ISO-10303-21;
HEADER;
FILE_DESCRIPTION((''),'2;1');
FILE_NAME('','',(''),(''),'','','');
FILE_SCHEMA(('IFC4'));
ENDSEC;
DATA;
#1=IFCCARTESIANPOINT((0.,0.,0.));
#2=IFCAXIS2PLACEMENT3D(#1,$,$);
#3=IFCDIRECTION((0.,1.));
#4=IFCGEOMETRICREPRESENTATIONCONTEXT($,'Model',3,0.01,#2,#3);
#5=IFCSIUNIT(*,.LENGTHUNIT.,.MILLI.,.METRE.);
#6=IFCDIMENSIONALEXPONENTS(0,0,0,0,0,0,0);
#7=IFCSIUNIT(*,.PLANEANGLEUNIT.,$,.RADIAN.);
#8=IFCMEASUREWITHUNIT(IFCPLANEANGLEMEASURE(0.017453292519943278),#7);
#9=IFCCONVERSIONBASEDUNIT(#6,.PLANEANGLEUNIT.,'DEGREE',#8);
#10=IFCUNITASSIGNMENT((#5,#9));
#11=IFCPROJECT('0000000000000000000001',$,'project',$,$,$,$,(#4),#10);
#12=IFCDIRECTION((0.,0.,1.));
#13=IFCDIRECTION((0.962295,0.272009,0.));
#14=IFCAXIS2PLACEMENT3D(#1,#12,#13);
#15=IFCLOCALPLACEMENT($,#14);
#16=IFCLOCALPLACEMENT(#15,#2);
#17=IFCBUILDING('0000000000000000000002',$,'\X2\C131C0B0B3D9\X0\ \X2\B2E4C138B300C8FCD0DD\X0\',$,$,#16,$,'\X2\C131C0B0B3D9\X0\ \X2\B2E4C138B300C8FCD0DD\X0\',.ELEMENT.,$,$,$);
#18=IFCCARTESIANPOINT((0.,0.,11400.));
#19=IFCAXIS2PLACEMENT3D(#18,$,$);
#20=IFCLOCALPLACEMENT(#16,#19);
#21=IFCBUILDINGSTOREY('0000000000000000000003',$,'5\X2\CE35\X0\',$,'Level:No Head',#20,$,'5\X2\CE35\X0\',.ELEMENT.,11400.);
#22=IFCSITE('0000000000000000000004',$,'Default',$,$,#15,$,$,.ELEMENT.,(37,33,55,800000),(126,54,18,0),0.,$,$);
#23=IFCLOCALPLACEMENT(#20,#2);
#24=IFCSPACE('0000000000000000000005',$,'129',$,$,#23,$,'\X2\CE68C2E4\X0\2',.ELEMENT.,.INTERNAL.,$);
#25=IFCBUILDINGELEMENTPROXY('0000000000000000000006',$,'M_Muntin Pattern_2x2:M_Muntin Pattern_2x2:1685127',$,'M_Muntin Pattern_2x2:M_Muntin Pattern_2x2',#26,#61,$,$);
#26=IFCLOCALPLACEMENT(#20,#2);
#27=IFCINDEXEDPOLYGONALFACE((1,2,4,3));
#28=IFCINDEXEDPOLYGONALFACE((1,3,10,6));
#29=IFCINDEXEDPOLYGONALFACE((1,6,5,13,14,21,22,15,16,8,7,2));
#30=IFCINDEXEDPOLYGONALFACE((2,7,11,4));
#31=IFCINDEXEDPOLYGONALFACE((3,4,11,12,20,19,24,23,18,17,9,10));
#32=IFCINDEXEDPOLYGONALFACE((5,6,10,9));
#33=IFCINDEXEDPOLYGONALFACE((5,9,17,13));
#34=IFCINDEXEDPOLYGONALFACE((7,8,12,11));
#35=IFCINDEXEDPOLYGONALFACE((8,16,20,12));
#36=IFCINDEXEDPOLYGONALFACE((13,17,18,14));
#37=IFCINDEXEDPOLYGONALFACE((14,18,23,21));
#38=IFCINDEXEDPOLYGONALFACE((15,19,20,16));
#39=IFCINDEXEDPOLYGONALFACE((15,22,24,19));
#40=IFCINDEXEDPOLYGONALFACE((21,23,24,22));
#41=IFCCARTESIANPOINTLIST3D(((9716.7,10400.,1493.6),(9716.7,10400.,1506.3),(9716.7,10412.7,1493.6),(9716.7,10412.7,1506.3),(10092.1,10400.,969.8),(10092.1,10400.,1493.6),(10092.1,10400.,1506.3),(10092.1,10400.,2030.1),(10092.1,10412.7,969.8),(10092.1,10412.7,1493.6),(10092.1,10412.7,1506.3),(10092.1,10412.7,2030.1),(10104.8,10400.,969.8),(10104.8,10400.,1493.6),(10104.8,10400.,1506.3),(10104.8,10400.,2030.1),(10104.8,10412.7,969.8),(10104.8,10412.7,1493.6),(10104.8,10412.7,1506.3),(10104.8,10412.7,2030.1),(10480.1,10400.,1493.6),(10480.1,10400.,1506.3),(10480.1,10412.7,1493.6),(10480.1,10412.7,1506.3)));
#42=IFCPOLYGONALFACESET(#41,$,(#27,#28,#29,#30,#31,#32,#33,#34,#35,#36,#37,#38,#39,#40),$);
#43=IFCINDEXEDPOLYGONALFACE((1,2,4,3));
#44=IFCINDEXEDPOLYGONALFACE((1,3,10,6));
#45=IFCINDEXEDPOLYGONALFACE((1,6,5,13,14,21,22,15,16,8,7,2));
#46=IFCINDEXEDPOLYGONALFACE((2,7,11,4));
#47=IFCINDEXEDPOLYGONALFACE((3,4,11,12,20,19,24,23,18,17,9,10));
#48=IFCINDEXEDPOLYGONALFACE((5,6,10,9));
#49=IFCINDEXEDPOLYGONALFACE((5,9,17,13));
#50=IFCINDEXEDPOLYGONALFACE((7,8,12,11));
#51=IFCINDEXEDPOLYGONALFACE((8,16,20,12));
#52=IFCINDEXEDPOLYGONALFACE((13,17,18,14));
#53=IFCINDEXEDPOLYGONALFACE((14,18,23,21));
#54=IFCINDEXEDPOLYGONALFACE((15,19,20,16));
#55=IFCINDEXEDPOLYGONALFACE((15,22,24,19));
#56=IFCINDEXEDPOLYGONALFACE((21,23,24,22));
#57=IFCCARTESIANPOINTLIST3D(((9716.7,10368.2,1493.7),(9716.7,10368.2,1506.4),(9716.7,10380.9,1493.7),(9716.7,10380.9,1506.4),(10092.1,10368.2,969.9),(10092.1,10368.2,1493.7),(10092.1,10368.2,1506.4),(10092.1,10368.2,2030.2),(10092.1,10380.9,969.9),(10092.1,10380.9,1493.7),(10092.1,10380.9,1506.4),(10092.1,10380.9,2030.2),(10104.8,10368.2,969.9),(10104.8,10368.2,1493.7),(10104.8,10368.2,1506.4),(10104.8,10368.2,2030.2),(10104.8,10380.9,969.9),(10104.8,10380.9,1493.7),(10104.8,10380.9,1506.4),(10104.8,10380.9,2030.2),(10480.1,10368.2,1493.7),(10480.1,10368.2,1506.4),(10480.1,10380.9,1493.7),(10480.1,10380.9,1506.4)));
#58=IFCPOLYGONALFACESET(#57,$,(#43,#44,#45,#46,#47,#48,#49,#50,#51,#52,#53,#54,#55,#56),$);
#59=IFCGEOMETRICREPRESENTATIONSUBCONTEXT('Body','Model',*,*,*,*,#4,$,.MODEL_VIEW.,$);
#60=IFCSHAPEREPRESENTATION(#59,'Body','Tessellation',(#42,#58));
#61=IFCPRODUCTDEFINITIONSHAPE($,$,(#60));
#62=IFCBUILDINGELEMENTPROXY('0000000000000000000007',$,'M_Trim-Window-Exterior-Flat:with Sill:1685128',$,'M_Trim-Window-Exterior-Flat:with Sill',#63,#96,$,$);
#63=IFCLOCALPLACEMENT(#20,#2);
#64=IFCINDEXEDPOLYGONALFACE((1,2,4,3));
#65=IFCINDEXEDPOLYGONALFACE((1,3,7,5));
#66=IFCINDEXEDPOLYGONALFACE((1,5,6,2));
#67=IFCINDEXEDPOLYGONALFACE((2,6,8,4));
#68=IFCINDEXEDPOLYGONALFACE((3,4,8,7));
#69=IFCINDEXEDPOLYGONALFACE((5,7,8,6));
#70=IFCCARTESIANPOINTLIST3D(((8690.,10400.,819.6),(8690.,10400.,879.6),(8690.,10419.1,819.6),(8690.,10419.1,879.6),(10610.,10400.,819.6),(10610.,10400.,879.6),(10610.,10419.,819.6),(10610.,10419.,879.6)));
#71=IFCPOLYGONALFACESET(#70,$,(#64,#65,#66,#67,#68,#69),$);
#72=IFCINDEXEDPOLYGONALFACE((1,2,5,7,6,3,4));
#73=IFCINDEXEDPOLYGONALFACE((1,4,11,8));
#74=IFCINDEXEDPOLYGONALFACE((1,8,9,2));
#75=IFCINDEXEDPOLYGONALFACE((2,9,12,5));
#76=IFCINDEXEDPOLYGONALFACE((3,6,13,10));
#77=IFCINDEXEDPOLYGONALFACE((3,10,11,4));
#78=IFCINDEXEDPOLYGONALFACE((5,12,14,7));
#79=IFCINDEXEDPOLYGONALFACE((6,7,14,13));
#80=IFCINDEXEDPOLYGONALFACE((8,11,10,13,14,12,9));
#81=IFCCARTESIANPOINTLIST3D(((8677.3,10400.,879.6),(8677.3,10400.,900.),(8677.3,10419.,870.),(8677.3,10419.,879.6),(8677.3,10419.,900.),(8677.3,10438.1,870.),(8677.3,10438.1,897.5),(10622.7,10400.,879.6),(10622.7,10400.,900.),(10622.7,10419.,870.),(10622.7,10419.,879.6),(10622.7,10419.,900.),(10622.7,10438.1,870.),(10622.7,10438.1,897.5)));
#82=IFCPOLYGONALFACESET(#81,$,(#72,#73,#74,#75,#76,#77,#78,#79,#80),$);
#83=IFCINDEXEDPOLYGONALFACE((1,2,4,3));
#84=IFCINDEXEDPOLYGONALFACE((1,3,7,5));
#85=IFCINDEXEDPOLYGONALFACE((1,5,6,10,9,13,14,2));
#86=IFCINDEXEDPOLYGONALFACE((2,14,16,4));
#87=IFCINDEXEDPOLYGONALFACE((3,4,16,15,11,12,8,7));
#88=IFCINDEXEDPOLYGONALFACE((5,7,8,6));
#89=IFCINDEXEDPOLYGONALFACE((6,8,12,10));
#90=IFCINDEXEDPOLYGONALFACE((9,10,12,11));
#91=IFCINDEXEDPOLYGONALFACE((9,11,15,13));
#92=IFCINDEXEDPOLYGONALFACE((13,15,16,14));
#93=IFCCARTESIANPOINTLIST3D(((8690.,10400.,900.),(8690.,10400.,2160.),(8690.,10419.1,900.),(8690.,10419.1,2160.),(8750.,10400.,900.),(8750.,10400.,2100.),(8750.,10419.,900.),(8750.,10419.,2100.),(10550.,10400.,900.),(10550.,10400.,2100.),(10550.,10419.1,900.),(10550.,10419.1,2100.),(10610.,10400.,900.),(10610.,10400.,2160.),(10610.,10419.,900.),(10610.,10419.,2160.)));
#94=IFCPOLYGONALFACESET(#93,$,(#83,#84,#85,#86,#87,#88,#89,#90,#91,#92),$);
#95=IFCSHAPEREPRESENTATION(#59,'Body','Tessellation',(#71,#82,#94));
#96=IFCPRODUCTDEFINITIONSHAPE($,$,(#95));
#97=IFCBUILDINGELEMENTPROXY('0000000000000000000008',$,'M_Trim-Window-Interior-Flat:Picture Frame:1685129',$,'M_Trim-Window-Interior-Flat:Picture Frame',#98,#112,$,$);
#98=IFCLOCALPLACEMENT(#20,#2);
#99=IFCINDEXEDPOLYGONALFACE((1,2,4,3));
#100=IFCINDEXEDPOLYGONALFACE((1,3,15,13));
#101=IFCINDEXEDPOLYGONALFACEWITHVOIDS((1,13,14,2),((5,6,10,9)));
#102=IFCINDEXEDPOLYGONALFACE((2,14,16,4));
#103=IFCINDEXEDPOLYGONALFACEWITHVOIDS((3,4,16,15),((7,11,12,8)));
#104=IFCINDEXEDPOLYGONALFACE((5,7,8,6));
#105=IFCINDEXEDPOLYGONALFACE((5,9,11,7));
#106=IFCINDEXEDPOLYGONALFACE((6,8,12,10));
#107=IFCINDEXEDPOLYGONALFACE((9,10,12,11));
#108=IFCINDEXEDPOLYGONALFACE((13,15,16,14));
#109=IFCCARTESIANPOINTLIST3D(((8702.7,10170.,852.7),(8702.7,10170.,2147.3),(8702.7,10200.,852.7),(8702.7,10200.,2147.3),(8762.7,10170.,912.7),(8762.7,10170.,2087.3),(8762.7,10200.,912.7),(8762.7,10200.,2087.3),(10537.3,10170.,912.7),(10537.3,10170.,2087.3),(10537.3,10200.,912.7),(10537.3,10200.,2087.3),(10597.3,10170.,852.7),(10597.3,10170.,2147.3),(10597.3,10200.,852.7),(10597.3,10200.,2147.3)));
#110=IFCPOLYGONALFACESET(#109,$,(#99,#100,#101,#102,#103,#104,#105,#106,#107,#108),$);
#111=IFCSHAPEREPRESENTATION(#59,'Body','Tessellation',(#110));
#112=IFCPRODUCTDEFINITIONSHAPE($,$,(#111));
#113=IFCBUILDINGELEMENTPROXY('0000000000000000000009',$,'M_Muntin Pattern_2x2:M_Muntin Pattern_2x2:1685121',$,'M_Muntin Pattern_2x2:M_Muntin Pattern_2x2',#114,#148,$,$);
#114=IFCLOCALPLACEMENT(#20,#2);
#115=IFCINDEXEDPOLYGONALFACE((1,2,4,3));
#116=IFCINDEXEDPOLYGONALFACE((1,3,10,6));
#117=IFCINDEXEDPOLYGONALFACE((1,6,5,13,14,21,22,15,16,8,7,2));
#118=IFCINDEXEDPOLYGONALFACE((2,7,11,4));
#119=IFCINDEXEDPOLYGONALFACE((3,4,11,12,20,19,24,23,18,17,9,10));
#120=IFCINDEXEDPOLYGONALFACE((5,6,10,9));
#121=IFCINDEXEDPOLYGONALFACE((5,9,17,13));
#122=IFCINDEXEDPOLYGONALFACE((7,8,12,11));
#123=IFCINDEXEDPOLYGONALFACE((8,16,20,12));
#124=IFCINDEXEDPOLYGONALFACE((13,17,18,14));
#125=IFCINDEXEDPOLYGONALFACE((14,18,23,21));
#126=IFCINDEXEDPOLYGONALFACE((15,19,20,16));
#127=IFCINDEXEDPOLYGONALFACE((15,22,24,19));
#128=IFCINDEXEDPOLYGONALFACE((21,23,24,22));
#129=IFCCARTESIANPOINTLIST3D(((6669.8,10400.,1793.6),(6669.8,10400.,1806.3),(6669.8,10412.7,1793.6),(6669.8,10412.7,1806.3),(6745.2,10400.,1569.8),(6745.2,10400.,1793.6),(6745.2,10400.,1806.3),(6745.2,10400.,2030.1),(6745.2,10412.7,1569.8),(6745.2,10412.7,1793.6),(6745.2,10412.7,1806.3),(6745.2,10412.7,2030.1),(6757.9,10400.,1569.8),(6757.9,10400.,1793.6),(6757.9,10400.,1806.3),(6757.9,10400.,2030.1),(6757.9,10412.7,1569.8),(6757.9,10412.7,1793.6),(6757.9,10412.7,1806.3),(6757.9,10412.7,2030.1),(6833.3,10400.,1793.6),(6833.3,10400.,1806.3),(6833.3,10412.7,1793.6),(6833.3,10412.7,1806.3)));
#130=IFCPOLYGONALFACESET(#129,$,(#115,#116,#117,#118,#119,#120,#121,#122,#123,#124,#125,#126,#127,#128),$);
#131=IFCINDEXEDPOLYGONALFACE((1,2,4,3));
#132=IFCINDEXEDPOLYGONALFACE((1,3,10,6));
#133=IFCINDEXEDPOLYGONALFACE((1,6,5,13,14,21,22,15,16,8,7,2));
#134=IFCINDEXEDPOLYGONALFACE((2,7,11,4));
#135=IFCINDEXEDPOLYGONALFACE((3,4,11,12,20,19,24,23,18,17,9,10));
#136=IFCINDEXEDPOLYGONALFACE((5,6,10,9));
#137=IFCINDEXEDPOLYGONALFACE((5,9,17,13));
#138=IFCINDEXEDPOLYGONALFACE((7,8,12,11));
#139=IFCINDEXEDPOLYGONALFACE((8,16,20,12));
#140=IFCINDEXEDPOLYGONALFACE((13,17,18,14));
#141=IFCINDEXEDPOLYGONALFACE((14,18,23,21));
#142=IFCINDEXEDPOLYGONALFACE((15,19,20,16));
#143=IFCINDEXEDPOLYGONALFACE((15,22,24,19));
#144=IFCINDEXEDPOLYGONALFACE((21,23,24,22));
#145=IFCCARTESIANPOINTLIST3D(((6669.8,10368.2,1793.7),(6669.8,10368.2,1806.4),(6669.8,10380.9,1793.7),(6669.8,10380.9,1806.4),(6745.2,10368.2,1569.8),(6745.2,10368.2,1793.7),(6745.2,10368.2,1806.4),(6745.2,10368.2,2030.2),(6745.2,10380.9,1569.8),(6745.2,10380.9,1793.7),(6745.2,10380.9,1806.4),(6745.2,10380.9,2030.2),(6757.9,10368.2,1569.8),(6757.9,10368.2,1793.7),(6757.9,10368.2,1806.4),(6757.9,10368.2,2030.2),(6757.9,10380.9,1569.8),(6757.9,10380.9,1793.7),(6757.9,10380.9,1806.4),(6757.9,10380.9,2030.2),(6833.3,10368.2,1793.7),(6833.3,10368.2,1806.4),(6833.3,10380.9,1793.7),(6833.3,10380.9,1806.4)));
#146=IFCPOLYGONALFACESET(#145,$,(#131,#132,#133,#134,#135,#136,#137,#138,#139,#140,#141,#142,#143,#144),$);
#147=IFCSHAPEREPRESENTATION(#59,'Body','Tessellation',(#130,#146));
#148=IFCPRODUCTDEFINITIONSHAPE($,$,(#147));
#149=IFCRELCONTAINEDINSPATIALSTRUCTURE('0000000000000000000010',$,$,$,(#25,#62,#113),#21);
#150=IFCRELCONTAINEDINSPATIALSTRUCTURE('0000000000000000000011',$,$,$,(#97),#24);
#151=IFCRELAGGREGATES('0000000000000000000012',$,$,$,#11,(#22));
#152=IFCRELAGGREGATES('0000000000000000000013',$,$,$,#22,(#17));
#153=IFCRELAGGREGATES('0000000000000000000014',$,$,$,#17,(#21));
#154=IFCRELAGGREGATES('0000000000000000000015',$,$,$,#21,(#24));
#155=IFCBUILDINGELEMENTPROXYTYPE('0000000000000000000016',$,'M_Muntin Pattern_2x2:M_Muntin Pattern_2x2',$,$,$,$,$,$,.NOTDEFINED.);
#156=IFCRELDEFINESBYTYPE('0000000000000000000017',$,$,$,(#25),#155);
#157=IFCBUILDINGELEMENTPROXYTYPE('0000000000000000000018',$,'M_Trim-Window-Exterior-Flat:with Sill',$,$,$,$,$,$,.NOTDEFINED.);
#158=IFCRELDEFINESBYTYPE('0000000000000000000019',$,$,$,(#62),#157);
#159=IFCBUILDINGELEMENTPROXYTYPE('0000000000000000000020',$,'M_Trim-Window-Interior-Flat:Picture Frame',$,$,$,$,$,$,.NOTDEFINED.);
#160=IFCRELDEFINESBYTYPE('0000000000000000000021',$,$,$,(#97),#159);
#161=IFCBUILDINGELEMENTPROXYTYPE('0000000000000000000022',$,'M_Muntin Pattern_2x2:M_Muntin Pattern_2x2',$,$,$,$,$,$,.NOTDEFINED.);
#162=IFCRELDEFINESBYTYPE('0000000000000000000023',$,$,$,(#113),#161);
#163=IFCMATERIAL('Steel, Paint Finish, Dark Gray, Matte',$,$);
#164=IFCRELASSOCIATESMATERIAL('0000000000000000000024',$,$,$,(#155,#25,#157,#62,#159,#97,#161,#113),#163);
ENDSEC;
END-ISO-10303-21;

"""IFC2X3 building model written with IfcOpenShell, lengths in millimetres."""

from ifc_helpers import new_model, entity, si_unit, converted_unit, direction, frame, frame_2d, origin, place, context, subcontext, project, spatial, polyline, rectangle, outline, extrude, source, transform, mapped, material, type_object, type_shapes, element, save


model = new_model("IFC2X3")

# Units and contexts
model_context = context("Model", 3, precision=0.01, world=origin(), true_north=direction((0.0, 1.0)))
body_context = subcontext(model_context, "Body", "Model", "MODEL_VIEW")
ifc_project = project(units=[si_unit("LENGTHUNIT", "METRE", prefix="MILLI"), converted_unit("PLANEANGLEUNIT", "DEGREE", entity("IfcPlaneAngleMeasure", 0.017453292519943278), si_unit("PLANEANGLEUNIT", "RADIAN"), dimensions=[0, 0, 0, 0, 0, 0, 0])], contexts=[model_context])

# Site, building, storey
site_placement = place(None, frame((0.0, 0.0, 0.0), z_axis=(0.0, 0.0, 1.0), x_axis=(0.962295, 0.272009, 0.0)))
site = spatial("IfcSite", under=ifc_project, at=site_placement, Name="Default", CompositionType="ELEMENT", RefLatitude=(37, 33, 55, 800000), RefLongitude=(126, 54, 18, 0), RefElevation=0.0)
building_placement = place(site_placement, origin())
building = spatial("IfcBuilding", under=site, at=building_placement, Name="성산동 다세대주택", LongName="성산동 다세대주택", CompositionType="ELEMENT")
storey_placement = place(building_placement, frame((0.0, 0.0, 11400.0)))
storey = spatial("IfcBuildingStorey", under=building, at=storey_placement, Name="5층", ObjectType="Level:No Head", LongName="5층", CompositionType="ELEMENT", Elevation=11400.0)

# Shared definitions
space_1_placement = place(storey_placement, origin())
space_1 = spatial("IfcSpace", under=storey, at=space_1_placement, Name="129", LongName="침실2", CompositionType="ELEMENT", InteriorOrExteriorSpace="INTERNAL")

# Building element proxies
ifc_material_1 = material(Name="Steel, Paint Finish, Dark Gray, Matte")
building_element_proxy_type_1 = type_object("IfcBuildingElementProxyType", Name="M_Muntin Pattern_2x2:M_Muntin Pattern_2x2", PredefinedType="NOTDEFINED", material=ifc_material_1)
shared_shape_1 = source(origin(), body_context, "Body", "SweptSolid", [
    extrude(outline(polyline([(6.4, -6.4), (530.1, -6.4), (530.1, 6.3), (6.4, 6.3), (6.4, 381.7), (-6.3, 381.7), (-6.3, 6.3), (-530.2, 6.3), (-530.2, -6.4), (-6.3, -6.4), (-6.3, -381.7), (6.4, -381.7), (6.4, -6.4)])), frame((0.0, -22.2, 530.1), z_axis=(0.0, 1.0, 0.0), x_axis=(0.0, 0.0, 1.0)), (0.0, 0.0, 1.0), 12.7),
    extrude(outline(polyline([(6.4, -6.4), (530.2, -6.4), (530.2, 6.3), (6.4, 6.3), (6.4, 381.7), (-6.3, 381.7), (-6.3, 6.3), (-530.2, 6.3), (-530.2, -6.4), (-6.3, -6.4), (-6.3, -381.7), (6.4, -381.7), (6.4, -6.4)])), frame((0.0, 9.5, 530.2), z_axis=(0.0, 1.0, 0.0), x_axis=(0.0, 0.0, 1.0)), (0.0, 0.0, 1.0), 12.7),
])
type_shapes(building_element_proxy_type_1, [shared_shape_1])
proxy_1_placement = place(storey_placement, frame((10098.4, 10390.5, 969.9), z_axis=(0.0, 0.0, 1.0), x_axis=(-1.0, 0.0, 0.0)))
element("IfcBuildingElementProxy", 1, at=proxy_1_placement, inside=storey, type_object=building_element_proxy_type_1, material=ifc_material_1, Name="M_Muntin Pattern_2x2:M_Muntin Pattern_2x2:1685127", ObjectType="M_Muntin Pattern_2x2:M_Muntin Pattern_2x2", context=body_context, shape_type="MappedRepresentation", body=[
    mapped(shared_shape_1, transform((0.0, 0.0, 0.0), scale=1.0)),
])
building_element_proxy_type_2 = type_object("IfcBuildingElementProxyType", Name="M_Trim-Window-Exterior-Flat:with Sill", PredefinedType="NOTDEFINED", material=ifc_material_1)
shared_shape_2 = source(origin(), body_context, "Body", "SweptSolid", [
    extrude(rectangle(XDim=1920.0, YDim=60.0, at=frame_2d((0.0, 0.0), x_axis=(1.0, 0.0))), frame((0.0, -1250.4, 0.0), z_axis=(0.0, 0.0, 1.0), x_axis=(-1.0, 0.0, 0.0)), (0.0, 0.0, 1.0), 19.0),
    extrude(outline(polyline([(-19.0, -15.2), (0.0, -15.2), (0.0, -5.7), (19.0, -5.7), (19.0, 14.8), (0.0, 14.8), (-19.0, 12.3), (-19.0, -15.2)])), frame((-972.7, -1214.8, 19.0), z_axis=(1.0, 0.0, 0.0), x_axis=(0.0, 0.0, -1.0)), (0.0, 0.0, 1.0), 1945.4),
    extrude(outline(polyline([(-645.0, -960.0), (615.0, -960.0), (615.0, -900.0), (-585.0, -900.0), (-585.0, 900.0), (615.0, 900.0), (615.0, 960.0), (-645.0, 960.0), (-645.0, -960.0)])), frame((0.0, -585.0, 0.0), z_axis=(0.0, 0.0, 1.0), x_axis=(0.0, -1.0, 0.0)), (0.0, 0.0, 1.0), 19.0),
])
type_shapes(building_element_proxy_type_2, [shared_shape_2])
proxy_2_placement = place(storey_placement, frame((9650.0, 10400.0, 2100.0), z_axis=(0.0, 1.0, 0.0), x_axis=(-1.0, 0.0, 0.0)))
element("IfcBuildingElementProxy", 2, at=proxy_2_placement, inside=storey, type_object=building_element_proxy_type_2, material=ifc_material_1, Name="M_Trim-Window-Exterior-Flat:with Sill:1685128", ObjectType="M_Trim-Window-Exterior-Flat:with Sill", context=body_context, shape_type="MappedRepresentation", body=[
    mapped(shared_shape_2, transform((0.0, 0.0, 0.0), scale=1.0)),
])
building_element_proxy_type_3 = type_object("IfcBuildingElementProxyType", Name="M_Trim-Window-Interior-Flat:Picture Frame", PredefinedType="NOTDEFINED", material=ifc_material_1)
shared_shape_3 = source(origin(), body_context, "Body", "SweptSolid", [
    extrude(outline(polyline([(-947.3, -647.3), (947.3, -647.3), (947.3, 647.3), (-947.3, 647.3), (-947.3, -647.3)]), holes=[polyline([(-887.3, -587.3), (-887.3, 587.3), (887.3, 587.3), (887.3, -587.3), (-887.3, -587.3)])]), frame((0.0, -600.0, 0.0), z_axis=(0.0, 0.0, 1.0), x_axis=(-1.0, 0.0, 0.0)), (0.0, 0.0, 1.0), 30.0),
])
type_shapes(building_element_proxy_type_3, [shared_shape_3])
proxy_3_placement = place(space_1_placement, frame((9650.0, 10200.0, 2100.0), z_axis=(0.0, -1.0, 0.0), x_axis=(1.0, 0.0, 0.0)))
element("IfcBuildingElementProxy", 3, at=proxy_3_placement, inside=space_1, type_object=building_element_proxy_type_3, material=ifc_material_1, Name="M_Trim-Window-Interior-Flat:Picture Frame:1685129", ObjectType="M_Trim-Window-Interior-Flat:Picture Frame", context=body_context, shape_type="MappedRepresentation", body=[
    mapped(shared_shape_3, transform((0.0, 0.0, 0.0), scale=1.0)),
])
building_element_proxy_type_4 = type_object("IfcBuildingElementProxyType", Name="M_Muntin Pattern_2x2:M_Muntin Pattern_2x2", PredefinedType="NOTDEFINED", material=ifc_material_1)
shared_shape_4 = source(origin(), body_context, "Body", "SweptSolid", [
    extrude(outline(polyline([(6.4, -6.4), (230.1, -6.4), (230.1, 6.3), (6.4, 6.3), (6.4, 81.7), (-6.3, 81.7), (-6.3, 6.3), (-230.2, 6.3), (-230.2, -6.4), (-6.3, -6.4), (-6.3, -81.7), (6.4, -81.7), (6.4, -6.4)])), frame((0.0, 9.5, 230.1), z_axis=(0.0, 1.0, 0.0), x_axis=(0.0, 0.0, 1.0)), (0.0, 0.0, 1.0), 12.7),
    extrude(outline(polyline([(6.4, -6.4), (230.2, -6.4), (230.2, 6.3), (6.4, 6.3), (6.4, 81.7), (-6.3, 81.7), (-6.3, 6.3), (-230.2, 6.3), (-230.2, -6.4), (-6.3, -6.4), (-6.3, -81.7), (6.4, -81.7), (6.4, -6.4)])), frame((0.0, -22.2, 230.2), z_axis=(0.0, 1.0, 0.0), x_axis=(0.0, 0.0, 1.0)), (0.0, 0.0, 1.0), 12.7),
])
type_shapes(building_element_proxy_type_4, [shared_shape_4])
proxy_4_placement = place(storey_placement, frame((6751.6, 10390.5, 1569.8)))
element("IfcBuildingElementProxy", 4, at=proxy_4_placement, inside=storey, type_object=building_element_proxy_type_4, material=ifc_material_1, Name="M_Muntin Pattern_2x2:M_Muntin Pattern_2x2:1685121", ObjectType="M_Muntin Pattern_2x2:M_Muntin Pattern_2x2", context=body_context, shape_type="MappedRepresentation", body=[
    mapped(shared_shape_4, transform((0.0, 0.0, 0.0), scale=1.0)),
])

save(model, "model.ifc")
